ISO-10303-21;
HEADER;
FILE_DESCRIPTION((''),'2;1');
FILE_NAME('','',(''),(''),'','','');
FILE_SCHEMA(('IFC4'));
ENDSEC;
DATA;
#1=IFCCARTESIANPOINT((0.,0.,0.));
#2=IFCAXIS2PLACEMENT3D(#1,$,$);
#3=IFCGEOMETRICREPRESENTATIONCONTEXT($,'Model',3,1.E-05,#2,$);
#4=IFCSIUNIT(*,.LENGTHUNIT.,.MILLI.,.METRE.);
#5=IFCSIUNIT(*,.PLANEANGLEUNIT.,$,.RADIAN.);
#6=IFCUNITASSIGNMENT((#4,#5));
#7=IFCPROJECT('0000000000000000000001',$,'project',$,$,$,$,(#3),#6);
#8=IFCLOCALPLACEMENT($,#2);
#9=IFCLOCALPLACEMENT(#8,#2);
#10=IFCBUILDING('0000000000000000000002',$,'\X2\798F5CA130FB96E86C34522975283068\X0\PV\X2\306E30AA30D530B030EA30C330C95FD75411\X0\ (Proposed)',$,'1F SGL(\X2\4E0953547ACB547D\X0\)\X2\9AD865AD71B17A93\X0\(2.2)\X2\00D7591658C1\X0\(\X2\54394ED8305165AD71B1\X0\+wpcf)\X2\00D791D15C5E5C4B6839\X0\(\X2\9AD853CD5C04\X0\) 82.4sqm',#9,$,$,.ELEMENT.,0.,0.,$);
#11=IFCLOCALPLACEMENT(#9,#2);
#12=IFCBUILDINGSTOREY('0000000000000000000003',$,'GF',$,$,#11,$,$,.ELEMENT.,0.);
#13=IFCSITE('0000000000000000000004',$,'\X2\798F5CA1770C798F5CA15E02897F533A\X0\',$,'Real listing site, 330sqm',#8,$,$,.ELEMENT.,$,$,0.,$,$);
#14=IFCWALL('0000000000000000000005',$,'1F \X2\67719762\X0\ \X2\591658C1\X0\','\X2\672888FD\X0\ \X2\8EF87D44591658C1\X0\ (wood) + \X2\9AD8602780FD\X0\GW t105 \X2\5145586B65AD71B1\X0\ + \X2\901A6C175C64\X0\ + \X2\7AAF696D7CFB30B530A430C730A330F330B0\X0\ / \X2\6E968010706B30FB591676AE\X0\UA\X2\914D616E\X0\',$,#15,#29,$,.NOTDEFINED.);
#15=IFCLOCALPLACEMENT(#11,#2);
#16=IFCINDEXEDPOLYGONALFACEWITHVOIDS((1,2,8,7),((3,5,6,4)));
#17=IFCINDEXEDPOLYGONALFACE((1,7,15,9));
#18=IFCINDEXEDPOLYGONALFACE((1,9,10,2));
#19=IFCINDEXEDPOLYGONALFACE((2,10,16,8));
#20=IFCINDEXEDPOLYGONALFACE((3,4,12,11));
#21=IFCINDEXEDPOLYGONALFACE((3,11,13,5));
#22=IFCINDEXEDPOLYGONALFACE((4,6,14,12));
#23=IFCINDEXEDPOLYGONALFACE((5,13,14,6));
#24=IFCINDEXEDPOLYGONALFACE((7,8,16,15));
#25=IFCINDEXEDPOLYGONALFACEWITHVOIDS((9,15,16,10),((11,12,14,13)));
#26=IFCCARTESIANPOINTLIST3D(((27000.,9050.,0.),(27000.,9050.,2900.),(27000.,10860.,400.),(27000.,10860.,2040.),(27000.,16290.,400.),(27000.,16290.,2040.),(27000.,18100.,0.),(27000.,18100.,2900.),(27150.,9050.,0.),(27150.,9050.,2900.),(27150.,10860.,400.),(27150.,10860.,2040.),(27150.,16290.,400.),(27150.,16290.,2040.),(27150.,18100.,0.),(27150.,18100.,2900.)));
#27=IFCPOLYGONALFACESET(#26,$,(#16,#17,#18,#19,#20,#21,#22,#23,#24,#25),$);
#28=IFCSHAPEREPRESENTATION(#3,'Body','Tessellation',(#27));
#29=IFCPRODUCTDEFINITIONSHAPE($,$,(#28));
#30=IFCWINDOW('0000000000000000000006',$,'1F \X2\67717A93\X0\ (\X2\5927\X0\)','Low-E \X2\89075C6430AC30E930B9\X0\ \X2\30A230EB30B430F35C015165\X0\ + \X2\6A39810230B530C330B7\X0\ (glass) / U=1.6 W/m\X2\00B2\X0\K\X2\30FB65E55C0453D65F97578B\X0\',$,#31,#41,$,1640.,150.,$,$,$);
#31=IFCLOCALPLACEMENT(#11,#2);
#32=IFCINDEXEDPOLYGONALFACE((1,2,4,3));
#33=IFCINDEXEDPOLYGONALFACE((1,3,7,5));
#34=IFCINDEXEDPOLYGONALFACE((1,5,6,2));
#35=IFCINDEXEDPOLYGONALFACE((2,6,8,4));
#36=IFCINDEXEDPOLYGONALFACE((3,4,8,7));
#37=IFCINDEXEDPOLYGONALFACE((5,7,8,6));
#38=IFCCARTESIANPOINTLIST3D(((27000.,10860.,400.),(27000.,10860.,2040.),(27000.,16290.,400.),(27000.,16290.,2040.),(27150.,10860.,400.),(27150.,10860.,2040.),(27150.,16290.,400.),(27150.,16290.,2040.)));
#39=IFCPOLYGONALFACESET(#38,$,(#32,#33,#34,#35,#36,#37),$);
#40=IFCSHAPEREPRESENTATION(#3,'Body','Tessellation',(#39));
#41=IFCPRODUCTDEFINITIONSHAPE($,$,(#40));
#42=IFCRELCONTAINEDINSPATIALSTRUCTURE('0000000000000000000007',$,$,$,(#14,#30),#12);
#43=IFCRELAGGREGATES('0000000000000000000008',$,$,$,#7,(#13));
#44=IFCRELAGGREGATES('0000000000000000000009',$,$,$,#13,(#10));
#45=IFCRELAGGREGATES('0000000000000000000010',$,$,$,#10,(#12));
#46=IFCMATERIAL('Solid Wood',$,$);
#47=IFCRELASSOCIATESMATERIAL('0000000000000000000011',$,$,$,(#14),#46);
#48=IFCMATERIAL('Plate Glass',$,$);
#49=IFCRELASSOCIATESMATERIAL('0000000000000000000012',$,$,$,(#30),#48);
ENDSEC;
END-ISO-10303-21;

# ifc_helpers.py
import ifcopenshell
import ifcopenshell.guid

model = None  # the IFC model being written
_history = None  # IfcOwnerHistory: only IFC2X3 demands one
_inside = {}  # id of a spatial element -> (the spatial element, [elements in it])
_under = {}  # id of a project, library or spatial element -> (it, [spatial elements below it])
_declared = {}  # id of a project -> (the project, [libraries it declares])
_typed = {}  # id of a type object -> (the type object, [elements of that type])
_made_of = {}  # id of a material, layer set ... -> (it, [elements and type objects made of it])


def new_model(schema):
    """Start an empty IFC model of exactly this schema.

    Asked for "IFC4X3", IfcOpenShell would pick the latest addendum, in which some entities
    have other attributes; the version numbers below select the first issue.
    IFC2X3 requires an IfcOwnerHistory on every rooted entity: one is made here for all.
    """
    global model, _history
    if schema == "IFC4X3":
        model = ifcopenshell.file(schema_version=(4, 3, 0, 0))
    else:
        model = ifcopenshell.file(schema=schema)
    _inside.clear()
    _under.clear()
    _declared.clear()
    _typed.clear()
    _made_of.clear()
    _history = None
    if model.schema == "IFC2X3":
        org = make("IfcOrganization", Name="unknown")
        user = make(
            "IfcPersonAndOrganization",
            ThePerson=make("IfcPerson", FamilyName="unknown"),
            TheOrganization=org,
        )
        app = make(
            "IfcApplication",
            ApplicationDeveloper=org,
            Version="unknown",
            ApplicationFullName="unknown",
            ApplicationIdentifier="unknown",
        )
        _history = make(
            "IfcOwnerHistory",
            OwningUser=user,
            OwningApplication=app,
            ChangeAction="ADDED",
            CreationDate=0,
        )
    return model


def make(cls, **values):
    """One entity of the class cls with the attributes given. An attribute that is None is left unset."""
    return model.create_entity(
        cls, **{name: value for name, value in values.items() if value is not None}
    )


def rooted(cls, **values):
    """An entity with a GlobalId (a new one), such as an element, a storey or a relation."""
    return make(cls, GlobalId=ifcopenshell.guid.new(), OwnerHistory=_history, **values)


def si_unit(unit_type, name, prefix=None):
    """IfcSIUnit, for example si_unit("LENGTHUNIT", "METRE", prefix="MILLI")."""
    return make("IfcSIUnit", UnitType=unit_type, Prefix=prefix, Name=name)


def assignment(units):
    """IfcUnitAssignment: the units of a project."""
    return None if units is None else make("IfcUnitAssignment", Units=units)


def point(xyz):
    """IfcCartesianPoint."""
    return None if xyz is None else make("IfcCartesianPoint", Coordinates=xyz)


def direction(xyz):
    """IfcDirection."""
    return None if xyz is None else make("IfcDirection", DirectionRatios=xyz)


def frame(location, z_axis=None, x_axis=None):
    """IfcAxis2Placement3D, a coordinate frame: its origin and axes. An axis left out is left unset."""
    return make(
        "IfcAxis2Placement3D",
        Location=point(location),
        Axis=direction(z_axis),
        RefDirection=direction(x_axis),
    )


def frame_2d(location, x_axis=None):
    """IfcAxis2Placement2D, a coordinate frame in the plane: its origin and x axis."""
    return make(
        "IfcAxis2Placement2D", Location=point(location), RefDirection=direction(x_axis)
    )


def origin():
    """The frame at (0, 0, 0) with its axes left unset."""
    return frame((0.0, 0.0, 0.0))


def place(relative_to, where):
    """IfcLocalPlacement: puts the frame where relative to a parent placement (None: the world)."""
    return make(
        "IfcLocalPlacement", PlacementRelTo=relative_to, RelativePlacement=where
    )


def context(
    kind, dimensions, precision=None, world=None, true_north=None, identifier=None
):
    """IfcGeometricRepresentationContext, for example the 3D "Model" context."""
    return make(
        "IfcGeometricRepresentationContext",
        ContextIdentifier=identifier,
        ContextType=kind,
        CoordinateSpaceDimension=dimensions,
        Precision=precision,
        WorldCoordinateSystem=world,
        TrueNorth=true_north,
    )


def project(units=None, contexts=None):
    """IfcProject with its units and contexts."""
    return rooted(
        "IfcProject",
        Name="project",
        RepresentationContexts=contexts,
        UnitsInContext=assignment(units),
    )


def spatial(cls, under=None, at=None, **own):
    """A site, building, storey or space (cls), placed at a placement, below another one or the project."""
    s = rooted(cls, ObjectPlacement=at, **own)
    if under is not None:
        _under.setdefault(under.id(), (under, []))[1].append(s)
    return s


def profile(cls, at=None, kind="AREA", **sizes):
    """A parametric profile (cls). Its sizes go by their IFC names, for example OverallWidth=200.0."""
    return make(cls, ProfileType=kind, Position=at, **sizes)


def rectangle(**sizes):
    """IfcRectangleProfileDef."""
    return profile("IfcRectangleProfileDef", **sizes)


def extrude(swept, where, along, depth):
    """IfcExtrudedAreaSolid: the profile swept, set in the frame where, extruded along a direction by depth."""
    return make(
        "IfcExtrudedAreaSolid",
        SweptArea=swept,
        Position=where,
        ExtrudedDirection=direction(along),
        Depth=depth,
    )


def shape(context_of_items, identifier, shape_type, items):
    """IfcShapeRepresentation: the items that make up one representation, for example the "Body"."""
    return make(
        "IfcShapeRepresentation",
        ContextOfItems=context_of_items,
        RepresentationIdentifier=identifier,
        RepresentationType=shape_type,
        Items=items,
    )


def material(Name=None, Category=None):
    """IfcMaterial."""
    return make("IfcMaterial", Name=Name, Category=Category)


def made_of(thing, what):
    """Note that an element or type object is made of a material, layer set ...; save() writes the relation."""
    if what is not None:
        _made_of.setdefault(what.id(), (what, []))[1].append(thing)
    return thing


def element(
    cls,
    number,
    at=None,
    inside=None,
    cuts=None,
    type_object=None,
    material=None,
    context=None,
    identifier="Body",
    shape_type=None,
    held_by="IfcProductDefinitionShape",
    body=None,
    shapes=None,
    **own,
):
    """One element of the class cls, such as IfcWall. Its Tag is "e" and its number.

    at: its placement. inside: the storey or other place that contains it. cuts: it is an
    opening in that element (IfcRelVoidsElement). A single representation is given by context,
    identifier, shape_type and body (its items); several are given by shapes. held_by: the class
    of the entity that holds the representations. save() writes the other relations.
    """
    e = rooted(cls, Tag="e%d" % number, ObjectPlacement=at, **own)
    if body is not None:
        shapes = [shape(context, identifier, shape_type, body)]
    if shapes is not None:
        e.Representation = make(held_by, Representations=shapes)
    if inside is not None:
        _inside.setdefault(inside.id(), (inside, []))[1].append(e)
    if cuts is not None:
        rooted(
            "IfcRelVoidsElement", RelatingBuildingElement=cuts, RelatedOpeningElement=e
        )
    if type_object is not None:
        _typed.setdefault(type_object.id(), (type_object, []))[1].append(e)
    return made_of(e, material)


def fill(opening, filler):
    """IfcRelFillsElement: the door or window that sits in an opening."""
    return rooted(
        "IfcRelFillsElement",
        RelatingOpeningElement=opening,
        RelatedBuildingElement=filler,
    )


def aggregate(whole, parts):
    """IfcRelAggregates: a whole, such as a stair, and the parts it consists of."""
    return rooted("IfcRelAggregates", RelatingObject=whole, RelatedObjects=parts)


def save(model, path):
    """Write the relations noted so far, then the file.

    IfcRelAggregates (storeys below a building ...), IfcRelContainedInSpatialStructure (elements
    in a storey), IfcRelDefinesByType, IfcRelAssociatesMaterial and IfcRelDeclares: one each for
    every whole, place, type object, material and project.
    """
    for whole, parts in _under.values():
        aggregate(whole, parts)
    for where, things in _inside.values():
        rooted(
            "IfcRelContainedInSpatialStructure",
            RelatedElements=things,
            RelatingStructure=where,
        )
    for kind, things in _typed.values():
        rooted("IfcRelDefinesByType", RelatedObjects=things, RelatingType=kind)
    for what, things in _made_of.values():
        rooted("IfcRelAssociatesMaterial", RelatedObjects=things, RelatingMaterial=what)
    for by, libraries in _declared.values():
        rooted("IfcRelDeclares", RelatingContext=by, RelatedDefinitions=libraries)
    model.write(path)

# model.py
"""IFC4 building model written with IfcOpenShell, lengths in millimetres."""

from ifc_helpers import new_model, si_unit, frame, frame_2d, origin, place, context, project, spatial, rectangle, extrude, material, element, fill, save


model = new_model("IFC4")

# Units and contexts
model_context = context("Model", 3, precision=1e-05, world=origin())
ifc_project = project(units=[si_unit("LENGTHUNIT", "METRE", prefix="MILLI"), si_unit("PLANEANGLEUNIT", "RADIAN")], contexts=[model_context])

# Site, building, storey
site_placement = place(None, origin())
site = spatial("IfcSite", under=ifc_project, at=site_placement, Name="福岡県福岡市西区", ObjectType="Real listing site, 330sqm", CompositionType="ELEMENT", RefElevation=0.0)
building_placement = place(site_placement, origin())
building = spatial("IfcBuilding", under=site, at=building_placement, Name="福岡・雨水利用とPVのオフグリッド志向 (Proposed)", ObjectType="1F SGL(三協立命)高断熱窓(2.2)×外壁(吹付け断熱+wpcf)×金属屋根(高反射) 82.4sqm", CompositionType="ELEMENT", ElevationOfRefHeight=0.0, ElevationOfTerrain=0.0)
storey_placement = place(building_placement, origin())
storey = spatial("IfcBuildingStorey", under=building, at=storey_placement, Name="GF", CompositionType="ELEMENT", Elevation=0.0)

# Shared definitions
ifc_material_1 = material(Name="Solid Wood")

# Wall, opening, window
wall_1_placement = place(storey_placement, frame((13500.0, 4525.0, 0.0)))
wall_1 = element("IfcWall", 1, at=wall_1_placement, inside=storey, material=ifc_material_1, Name="1F 東面 外壁", Description="木製 軸組外壁 (wood) + 高性能GW t105 充填断熱 + 通気層 + 窯業系サイディング / 準耐火・外皮UA配慮", PredefinedType="NOTDEFINED", context=model_context, shape_type="SweptSolid", body=[
    extrude(rectangle(XDim=150.0, YDim=9050.0, at=frame_2d((75.0, 4525.0))), frame((13500.0, 4525.0, 0.0)), (0.0, 0.0, 1.0), 2900.0),
])
opening_placement = place(storey_placement, frame((13500.0, 5430.0, 200.0)))
opening = element("IfcOpeningElement", 2, at=opening_placement, cuts=wall_1, PredefinedType="NOTDEFINED", context=model_context, shape_type="SweptSolid", body=[
    extrude(rectangle(XDim=150.0, YDim=5430.0, at=frame_2d((75.0, 2715.0))), frame((13500.0, 5430.0, 200.0)), (0.0, 0.0, 1.0), 1640.0),
])
ifc_material_2 = material(Name="Plate Glass")
window_placement = place(storey_placement, frame((13500.0, 5430.0, 200.0)))
window = element("IfcWindow", 3, at=window_placement, inside=storey, material=ifc_material_2, Name="1F 東窓 (大)", Description="Low-E 複層ガラス アルゴン封入 + 樹脂サッシ (glass) / U=1.6 W/m²K・日射取得型", OverallHeight=1640.0, OverallWidth=150.0, context=model_context, shape_type="SweptSolid", body=[
    extrude(rectangle(XDim=150.0, YDim=5430.0, at=frame_2d((75.0, 2715.0))), frame((13500.0, 5430.0, 200.0)), (0.0, 0.0, 1.0), 1640.0),
])
fill(opening, window)

save(model, "model.ifc")
